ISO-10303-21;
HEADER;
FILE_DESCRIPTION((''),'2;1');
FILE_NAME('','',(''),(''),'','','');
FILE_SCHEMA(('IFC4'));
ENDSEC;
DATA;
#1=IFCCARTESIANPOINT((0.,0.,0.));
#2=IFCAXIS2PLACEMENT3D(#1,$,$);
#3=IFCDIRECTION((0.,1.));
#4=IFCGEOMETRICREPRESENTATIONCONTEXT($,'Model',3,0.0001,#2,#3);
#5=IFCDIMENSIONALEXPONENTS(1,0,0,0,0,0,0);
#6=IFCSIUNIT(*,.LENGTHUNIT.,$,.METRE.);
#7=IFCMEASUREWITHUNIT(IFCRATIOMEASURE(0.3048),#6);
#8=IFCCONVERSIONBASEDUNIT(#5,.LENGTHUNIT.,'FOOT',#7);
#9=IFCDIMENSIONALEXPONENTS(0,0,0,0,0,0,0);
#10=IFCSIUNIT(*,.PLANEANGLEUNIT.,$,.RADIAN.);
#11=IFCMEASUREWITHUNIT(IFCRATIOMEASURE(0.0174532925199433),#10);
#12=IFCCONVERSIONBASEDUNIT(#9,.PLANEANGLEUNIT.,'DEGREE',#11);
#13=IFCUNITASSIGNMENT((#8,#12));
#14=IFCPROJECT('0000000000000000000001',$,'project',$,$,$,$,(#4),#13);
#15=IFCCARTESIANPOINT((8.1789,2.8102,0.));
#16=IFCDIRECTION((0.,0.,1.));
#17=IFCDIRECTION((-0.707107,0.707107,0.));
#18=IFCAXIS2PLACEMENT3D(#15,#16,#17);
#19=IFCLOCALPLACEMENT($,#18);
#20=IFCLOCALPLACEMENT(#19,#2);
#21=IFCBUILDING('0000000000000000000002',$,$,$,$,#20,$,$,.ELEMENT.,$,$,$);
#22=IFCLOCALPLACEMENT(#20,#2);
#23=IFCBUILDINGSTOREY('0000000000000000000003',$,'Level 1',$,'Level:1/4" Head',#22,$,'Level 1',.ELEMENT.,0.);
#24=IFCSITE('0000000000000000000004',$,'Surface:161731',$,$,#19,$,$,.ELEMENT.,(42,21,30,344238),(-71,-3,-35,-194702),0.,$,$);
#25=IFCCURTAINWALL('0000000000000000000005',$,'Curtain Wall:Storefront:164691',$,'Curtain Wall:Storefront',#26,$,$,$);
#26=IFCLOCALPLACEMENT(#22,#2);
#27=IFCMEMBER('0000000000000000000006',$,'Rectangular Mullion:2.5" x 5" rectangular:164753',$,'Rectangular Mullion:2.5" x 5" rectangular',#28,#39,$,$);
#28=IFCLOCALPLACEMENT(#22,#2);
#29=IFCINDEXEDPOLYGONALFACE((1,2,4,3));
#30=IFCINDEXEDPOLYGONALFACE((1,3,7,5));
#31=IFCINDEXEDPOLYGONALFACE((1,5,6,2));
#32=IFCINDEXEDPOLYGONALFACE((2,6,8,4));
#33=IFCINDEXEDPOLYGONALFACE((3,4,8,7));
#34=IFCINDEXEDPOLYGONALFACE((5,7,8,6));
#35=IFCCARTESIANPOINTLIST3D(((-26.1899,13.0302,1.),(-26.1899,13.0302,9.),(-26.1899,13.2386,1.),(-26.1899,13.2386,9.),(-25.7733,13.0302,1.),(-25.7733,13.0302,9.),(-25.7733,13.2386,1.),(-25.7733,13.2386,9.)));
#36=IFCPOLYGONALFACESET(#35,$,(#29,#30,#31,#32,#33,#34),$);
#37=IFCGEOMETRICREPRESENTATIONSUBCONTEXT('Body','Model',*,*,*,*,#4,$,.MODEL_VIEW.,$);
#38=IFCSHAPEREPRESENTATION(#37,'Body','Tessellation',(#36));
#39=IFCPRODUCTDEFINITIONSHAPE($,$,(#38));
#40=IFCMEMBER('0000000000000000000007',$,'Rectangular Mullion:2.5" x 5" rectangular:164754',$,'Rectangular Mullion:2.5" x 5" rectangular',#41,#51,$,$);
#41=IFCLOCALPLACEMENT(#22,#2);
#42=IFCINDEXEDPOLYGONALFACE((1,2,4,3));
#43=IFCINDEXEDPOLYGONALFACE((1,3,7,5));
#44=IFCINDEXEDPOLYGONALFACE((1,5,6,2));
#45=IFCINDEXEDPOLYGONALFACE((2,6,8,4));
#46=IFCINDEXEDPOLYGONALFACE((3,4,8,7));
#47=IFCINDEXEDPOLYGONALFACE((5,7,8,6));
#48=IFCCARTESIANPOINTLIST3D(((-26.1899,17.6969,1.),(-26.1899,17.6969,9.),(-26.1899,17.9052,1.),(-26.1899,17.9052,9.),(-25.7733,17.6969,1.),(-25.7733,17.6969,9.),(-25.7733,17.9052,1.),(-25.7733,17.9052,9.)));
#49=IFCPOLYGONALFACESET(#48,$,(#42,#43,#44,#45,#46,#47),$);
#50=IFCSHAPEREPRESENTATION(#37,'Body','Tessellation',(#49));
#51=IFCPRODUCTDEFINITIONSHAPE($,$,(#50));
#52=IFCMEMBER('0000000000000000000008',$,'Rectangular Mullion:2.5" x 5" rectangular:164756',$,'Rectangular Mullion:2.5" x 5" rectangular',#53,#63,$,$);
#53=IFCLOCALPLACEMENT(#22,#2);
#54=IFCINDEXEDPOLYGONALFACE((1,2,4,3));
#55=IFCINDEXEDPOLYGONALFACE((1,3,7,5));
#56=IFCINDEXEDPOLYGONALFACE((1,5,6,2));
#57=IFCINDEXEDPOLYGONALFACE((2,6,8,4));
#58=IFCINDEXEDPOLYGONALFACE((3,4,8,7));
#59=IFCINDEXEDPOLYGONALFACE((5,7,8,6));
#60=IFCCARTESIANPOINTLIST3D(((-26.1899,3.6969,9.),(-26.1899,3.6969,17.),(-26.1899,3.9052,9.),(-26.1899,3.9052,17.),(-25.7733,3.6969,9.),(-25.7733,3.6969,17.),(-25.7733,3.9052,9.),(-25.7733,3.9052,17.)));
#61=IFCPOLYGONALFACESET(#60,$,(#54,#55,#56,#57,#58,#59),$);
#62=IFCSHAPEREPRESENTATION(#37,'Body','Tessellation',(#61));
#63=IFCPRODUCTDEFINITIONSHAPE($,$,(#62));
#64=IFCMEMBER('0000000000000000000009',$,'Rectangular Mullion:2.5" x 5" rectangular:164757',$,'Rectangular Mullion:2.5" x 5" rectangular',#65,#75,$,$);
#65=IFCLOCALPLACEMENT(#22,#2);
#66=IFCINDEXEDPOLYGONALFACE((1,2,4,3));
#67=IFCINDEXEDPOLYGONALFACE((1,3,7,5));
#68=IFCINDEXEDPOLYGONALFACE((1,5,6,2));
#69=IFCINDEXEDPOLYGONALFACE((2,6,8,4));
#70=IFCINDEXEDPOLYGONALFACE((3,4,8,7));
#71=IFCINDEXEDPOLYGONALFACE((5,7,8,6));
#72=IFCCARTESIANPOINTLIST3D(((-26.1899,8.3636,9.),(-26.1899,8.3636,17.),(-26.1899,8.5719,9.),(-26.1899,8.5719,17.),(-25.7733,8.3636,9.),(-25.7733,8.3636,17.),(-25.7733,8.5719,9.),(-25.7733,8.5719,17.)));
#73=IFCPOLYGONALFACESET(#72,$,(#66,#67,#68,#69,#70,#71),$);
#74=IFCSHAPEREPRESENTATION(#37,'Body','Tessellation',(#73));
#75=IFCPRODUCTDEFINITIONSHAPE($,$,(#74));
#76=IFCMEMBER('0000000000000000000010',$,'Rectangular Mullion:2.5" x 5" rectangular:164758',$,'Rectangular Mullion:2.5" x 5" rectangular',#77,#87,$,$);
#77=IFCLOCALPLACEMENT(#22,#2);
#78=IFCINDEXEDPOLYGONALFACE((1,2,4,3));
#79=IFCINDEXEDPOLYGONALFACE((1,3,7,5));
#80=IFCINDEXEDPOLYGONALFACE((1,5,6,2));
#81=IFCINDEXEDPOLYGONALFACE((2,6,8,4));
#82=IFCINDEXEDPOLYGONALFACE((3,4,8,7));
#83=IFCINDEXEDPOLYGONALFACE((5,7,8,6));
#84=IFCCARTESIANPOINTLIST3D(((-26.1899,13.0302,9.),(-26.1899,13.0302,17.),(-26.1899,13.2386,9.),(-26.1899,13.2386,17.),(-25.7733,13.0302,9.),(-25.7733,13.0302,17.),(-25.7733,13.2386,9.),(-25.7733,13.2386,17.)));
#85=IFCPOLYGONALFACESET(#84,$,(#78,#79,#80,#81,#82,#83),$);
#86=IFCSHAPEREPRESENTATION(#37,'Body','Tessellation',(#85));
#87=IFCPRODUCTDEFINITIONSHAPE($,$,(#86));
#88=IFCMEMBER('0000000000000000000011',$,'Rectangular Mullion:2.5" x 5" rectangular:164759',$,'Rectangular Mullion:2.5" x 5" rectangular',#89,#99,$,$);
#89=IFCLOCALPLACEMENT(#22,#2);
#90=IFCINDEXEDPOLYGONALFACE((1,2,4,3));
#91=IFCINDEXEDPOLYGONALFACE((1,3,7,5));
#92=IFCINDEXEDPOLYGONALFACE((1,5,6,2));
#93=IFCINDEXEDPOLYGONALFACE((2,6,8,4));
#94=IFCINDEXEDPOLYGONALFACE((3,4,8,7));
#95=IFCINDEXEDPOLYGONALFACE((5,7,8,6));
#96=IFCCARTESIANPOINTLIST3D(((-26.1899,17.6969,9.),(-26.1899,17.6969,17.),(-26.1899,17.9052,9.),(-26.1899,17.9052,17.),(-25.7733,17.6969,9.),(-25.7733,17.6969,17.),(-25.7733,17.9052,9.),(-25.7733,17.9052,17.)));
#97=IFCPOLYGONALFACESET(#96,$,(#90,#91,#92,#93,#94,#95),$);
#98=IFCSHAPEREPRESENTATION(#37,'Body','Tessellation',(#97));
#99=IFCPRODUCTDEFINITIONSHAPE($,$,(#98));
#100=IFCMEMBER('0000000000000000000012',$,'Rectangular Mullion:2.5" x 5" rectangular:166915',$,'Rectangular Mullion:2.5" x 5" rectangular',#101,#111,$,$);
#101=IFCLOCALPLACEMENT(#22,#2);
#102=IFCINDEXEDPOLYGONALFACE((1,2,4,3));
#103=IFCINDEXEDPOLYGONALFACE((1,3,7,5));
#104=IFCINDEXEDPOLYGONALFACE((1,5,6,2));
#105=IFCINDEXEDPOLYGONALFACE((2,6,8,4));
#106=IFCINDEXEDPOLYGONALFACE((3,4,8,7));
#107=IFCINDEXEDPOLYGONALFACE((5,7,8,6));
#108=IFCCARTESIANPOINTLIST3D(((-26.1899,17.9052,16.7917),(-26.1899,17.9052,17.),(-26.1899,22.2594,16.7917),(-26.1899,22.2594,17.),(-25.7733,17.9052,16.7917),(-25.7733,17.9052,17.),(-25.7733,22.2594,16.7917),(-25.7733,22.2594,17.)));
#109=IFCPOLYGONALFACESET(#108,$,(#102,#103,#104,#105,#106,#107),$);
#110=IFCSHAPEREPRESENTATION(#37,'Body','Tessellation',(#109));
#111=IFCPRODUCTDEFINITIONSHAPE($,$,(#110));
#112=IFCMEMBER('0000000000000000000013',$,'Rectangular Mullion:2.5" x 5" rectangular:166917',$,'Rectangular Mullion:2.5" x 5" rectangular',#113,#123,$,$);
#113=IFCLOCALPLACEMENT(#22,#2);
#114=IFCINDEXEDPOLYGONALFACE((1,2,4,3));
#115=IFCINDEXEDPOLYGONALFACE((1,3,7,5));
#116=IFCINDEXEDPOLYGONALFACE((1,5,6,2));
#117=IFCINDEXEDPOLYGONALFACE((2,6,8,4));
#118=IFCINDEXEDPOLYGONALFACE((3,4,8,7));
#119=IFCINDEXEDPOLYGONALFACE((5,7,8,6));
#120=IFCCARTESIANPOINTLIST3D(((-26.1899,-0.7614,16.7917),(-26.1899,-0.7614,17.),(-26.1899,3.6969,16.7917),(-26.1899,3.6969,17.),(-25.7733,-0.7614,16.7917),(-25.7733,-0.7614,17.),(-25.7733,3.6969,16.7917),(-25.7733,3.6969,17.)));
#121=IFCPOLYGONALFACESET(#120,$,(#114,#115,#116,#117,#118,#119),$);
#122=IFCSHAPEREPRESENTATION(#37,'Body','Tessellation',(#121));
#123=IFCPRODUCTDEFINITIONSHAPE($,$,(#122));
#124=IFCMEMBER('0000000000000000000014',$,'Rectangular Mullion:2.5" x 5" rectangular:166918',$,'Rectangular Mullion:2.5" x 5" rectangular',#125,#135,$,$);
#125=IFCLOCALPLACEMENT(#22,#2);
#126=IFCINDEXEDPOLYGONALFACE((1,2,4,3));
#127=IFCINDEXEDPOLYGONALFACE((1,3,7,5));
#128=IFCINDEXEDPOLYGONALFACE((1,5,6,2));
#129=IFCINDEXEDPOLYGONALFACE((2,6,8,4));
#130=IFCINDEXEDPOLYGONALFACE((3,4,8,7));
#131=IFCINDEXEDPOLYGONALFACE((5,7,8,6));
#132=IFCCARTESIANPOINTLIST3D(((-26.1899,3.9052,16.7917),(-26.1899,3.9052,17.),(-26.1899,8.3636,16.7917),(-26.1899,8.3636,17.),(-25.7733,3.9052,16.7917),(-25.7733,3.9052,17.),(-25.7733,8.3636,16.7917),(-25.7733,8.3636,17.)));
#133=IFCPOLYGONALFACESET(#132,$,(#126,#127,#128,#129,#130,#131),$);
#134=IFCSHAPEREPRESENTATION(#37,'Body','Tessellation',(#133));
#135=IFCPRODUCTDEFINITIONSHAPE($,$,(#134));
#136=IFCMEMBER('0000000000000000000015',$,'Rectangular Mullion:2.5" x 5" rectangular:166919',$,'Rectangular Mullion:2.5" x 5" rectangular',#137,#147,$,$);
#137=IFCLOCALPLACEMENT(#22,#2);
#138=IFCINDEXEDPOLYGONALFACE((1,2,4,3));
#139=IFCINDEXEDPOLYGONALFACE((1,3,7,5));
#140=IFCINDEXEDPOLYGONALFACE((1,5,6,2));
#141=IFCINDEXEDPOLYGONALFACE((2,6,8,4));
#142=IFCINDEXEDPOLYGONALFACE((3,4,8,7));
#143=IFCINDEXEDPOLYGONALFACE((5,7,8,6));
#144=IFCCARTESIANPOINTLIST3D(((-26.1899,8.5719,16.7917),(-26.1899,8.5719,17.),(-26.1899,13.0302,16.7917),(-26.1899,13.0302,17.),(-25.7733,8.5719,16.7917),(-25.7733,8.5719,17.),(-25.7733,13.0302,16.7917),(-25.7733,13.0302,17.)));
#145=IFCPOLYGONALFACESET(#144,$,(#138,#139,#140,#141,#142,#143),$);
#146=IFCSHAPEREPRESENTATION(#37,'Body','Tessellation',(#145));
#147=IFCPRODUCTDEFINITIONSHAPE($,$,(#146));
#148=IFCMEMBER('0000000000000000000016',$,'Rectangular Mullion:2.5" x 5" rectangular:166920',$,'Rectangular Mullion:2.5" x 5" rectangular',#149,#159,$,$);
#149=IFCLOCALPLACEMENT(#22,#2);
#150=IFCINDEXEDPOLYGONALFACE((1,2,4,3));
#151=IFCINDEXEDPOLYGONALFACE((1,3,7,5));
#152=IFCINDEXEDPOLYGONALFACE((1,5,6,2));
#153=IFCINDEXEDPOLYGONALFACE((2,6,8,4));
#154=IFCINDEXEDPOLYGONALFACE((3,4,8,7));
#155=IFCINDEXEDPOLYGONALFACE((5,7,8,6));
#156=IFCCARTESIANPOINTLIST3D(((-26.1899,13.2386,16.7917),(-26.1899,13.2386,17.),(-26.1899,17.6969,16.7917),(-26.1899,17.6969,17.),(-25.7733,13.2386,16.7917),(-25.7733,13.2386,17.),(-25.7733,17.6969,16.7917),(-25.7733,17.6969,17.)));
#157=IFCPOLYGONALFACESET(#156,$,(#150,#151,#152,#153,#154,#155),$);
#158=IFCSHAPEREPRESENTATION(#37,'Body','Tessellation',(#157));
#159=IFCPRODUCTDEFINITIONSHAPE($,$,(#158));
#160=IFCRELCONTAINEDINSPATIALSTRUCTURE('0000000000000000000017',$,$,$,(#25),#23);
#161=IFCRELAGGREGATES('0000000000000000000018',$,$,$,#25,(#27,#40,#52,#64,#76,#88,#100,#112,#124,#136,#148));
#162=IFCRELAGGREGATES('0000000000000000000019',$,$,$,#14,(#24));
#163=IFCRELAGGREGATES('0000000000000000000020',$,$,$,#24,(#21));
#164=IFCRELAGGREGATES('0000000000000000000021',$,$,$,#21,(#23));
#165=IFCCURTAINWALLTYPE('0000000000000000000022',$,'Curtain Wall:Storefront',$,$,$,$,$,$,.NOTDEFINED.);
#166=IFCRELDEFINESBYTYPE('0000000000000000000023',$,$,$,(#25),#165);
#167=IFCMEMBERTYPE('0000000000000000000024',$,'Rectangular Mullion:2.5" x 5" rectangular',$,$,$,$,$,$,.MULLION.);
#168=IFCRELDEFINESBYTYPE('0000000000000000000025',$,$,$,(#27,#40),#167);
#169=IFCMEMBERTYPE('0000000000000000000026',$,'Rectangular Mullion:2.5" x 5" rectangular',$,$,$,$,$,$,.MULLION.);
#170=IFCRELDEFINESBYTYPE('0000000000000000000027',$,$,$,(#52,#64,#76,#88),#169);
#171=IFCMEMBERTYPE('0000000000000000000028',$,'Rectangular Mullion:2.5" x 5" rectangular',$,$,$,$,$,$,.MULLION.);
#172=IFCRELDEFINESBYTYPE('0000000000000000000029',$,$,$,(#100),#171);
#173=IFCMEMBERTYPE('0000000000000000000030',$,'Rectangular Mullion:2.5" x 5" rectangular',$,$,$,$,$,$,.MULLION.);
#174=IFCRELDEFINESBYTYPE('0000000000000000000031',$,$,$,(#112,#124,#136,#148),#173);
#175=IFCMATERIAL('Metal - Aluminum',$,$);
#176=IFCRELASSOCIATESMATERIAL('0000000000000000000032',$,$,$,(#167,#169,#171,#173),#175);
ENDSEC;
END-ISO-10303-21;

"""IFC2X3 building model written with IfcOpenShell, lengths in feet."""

from ifc_helpers import new_model, entity, si_unit, converted_unit, direction, frame, origin, origin_2d_with_axis, place, context, subcontext, project, spatial, rectangle, extrude, source, transform, mapped, material, type_object, type_shapes, element, aggregate, save


model = new_model("IFC2X3")

# Units and contexts
model_context = context("Model", 3, precision=0.0001, world=origin(), true_north=direction((0.0, 1.0)))
body_context = subcontext(model_context, "Body", "Model", "MODEL_VIEW")
ifc_project = project(units=[converted_unit("LENGTHUNIT", "FOOT", entity("IfcRatioMeasure", 0.3048), si_unit("LENGTHUNIT", "METRE"), dimensions=[1, 0, 0, 0, 0, 0, 0]), converted_unit("PLANEANGLEUNIT", "DEGREE", entity("IfcRatioMeasure", 0.0174532925199433), si_unit("PLANEANGLEUNIT", "RADIAN"), dimensions=[0, 0, 0, 0, 0, 0, 0])], contexts=[model_context])

# Site, building, storey
site_placement = place(None, frame((8.1789, 2.8102, 0.0), z_axis=(0.0, 0.0, 1.0), x_axis=(-0.707107, 0.707107, 0.0)))
site = spatial("IfcSite", under=ifc_project, at=site_placement, Name="Surface:161731", CompositionType="ELEMENT", RefLatitude=(42, 21, 30, 344238), RefLongitude=(-71, -3, -35, -194702), RefElevation=0.0)
building_placement = place(site_placement, origin())
building = spatial("IfcBuilding", under=site, at=building_placement, CompositionType="ELEMENT")
storey_placement = place(building_placement, origin())
storey = spatial("IfcBuildingStorey", under=building, at=storey_placement, Name="Level 1", ObjectType="Level:1/4\" Head", LongName="Level 1", CompositionType="ELEMENT", Elevation=0.0)

# Curtain wall, members
curtain_wall_type = type_object("IfcCurtainWallType", Name="Curtain Wall:Storefront", PredefinedType="NOTDEFINED")
curtain_wall_placement = place(storey_placement, origin())
curtain_wall = element("IfcCurtainWall", 1, at=curtain_wall_placement, inside=storey, type_object=curtain_wall_type, Name="Curtain Wall:Storefront:164691", ObjectType="Curtain Wall:Storefront")
ifc_material_1 = material(Name="Metal - Aluminum")
member_type_1 = type_object("IfcMemberType", Name="Rectangular Mullion:2.5\" x 5\" rectangular", PredefinedType="MULLION", material=ifc_material_1)
shared_shape_1 = source(origin(), body_context, "Body", "SweptSolid", [
    extrude(rectangle(XDim=0.4167, YDim=0.2083, at=origin_2d_with_axis()), frame((0.0, 0.0, -8.0), z_axis=(0.0, 0.0, 1.0), x_axis=(0.0, -1.0, 0.0)), (0.0, 0.0, 1.0), 8.0),
])
type_shapes(member_type_1, [shared_shape_1])
member_1_placement = place(curtain_wall_placement, frame((-25.9816, 13.1344, 1.0), z_axis=(0.0, 0.0, -1.0), x_axis=(0.0, 1.0, 0.0)))
member_1 = element("IfcMember", 2, at=member_1_placement, type_object=member_type_1, Name="Rectangular Mullion:2.5\" x 5\" rectangular:164753", ObjectType="Rectangular Mullion:2.5\" x 5\" rectangular", context=body_context, shape_type="MappedRepresentation", body=[
    mapped(shared_shape_1, transform((0.0, 0.0, 0.0), scale=1.0)),
])
member_2_placement = place(curtain_wall_placement, frame((-25.9816, 17.8011, 1.0), z_axis=(0.0, 0.0, -1.0), x_axis=(0.0, 1.0, 0.0)))
member_2 = element("IfcMember", 3, at=member_2_placement, type_object=member_type_1, Name="Rectangular Mullion:2.5\" x 5\" rectangular:164754", ObjectType="Rectangular Mullion:2.5\" x 5\" rectangular", context=body_context, shape_type="MappedRepresentation", body=[
    mapped(shared_shape_1, transform((0.0, 0.0, 0.0), scale=1.0)),
])
member_type_2 = type_object("IfcMemberType", Name="Rectangular Mullion:2.5\" x 5\" rectangular", PredefinedType="MULLION", material=ifc_material_1)
shared_shape_2 = source(origin(), body_context, "Body", "SweptSolid", [
    extrude(rectangle(XDim=0.4167, YDim=0.2083, at=origin_2d_with_axis()), frame((0.0, 0.0, -8.0), z_axis=(0.0, 0.0, 1.0), x_axis=(0.0, -1.0, 0.0)), (0.0, 0.0, 1.0), 8.0),
])
type_shapes(member_type_2, [shared_shape_2])
member_3_placement = place(curtain_wall_placement, frame((-25.9816, 3.8011, 9.0), z_axis=(0.0, 0.0, -1.0), x_axis=(0.0, 1.0, 0.0)))
member_3 = element("IfcMember", 4, at=member_3_placement, type_object=member_type_2, Name="Rectangular Mullion:2.5\" x 5\" rectangular:164756", ObjectType="Rectangular Mullion:2.5\" x 5\" rectangular", context=body_context, shape_type="MappedRepresentation", body=[
    mapped(shared_shape_2, transform((0.0, 0.0, 0.0), scale=1.0)),
])
member_4_placement = place(curtain_wall_placement, frame((-25.9816, 8.4677, 9.0), z_axis=(0.0, 0.0, -1.0), x_axis=(0.0, 1.0, 0.0)))
member_4 = element("IfcMember", 5, at=member_4_placement, type_object=member_type_2, Name="Rectangular Mullion:2.5\" x 5\" rectangular:164757", ObjectType="Rectangular Mullion:2.5\" x 5\" rectangular", context=body_context, shape_type="MappedRepresentation", body=[
    mapped(shared_shape_2, transform((0.0, 0.0, 0.0), scale=1.0)),
])
member_5_placement = place(curtain_wall_placement, frame((-25.9816, 13.1344, 9.0), z_axis=(0.0, 0.0, -1.0), x_axis=(0.0, 1.0, 0.0)))
member_5 = element("IfcMember", 6, at=member_5_placement, type_object=member_type_2, Name="Rectangular Mullion:2.5\" x 5\" rectangular:164758", ObjectType="Rectangular Mullion:2.5\" x 5\" rectangular", context=body_context, shape_type="MappedRepresentation", body=[
    mapped(shared_shape_2, transform((0.0, 0.0, 0.0), scale=1.0)),
])
member_6_placement = place(curtain_wall_placement, frame((-25.9816, 17.8011, 9.0), z_axis=(0.0, 0.0, -1.0), x_axis=(0.0, 1.0, 0.0)))
member_6 = element("IfcMember", 7, at=member_6_placement, type_object=member_type_2, Name="Rectangular Mullion:2.5\" x 5\" rectangular:164759", ObjectType="Rectangular Mullion:2.5\" x 5\" rectangular", context=body_context, shape_type="MappedRepresentation", body=[
    mapped(shared_shape_2, transform((0.0, 0.0, 0.0), scale=1.0)),
])
member_type_3 = type_object("IfcMemberType", Name="Rectangular Mullion:2.5\" x 5\" rectangular", PredefinedType="MULLION", material=ifc_material_1)
shared_shape_3 = source(origin(), body_context, "Body", "SweptSolid", [
    extrude(rectangle(XDim=0.4167, YDim=0.2083, at=origin_2d_with_axis()), frame((-0.1042, 0.0, -4.3542), z_axis=(0.0, 0.0, 1.0), x_axis=(0.0, -1.0, 0.0)), (0.0, 0.0, 1.0), 4.3542),
])
type_shapes(member_type_3, [shared_shape_3])
member_7_placement = place(curtain_wall_placement, frame((-25.9816, 22.2594, 17.0), z_axis=(0.0, 1.0, 0.0), x_axis=(0.0, 0.0, 1.0)))
member_7 = element("IfcMember", 8, at=member_7_placement, type_object=member_type_3, Name="Rectangular Mullion:2.5\" x 5\" rectangular:166915", ObjectType="Rectangular Mullion:2.5\" x 5\" rectangular", context=body_context, shape_type="MappedRepresentation", body=[
    mapped(shared_shape_3, transform((0.0, 0.0, 0.0), scale=1.0)),
])
member_type_4 = type_object("IfcMemberType", Name="Rectangular Mullion:2.5\" x 5\" rectangular", PredefinedType="MULLION", material=ifc_material_1)
shared_shape_4 = source(origin(), body_context, "Body", "SweptSolid", [
    extrude(rectangle(XDim=0.4167, YDim=0.2083, at=origin_2d_with_axis()), frame((-0.1042, 0.0, -4.4583), z_axis=(0.0, 0.0, 1.0), x_axis=(0.0, -1.0, 0.0)), (0.0, 0.0, 1.0), 4.4583),
])
type_shapes(member_type_4, [shared_shape_4])
member_8_placement = place(curtain_wall_placement, frame((-25.9816, 3.6969, 17.0), z_axis=(0.0, 1.0, 0.0), x_axis=(0.0, 0.0, 1.0)))
member_8 = element("IfcMember", 9, at=member_8_placement, type_object=member_type_4, Name="Rectangular Mullion:2.5\" x 5\" rectangular:166917", ObjectType="Rectangular Mullion:2.5\" x 5\" rectangular", context=body_context, shape_type="MappedRepresentation", body=[
    mapped(shared_shape_4, transform((0.0, 0.0, 0.0), scale=1.0)),
])
member_9_placement = place(curtain_wall_placement, frame((-25.9816, 8.3636, 17.0), z_axis=(0.0, 1.0, 0.0), x_axis=(0.0, 0.0, 1.0)))
member_9 = element("IfcMember", 10, at=member_9_placement, type_object=member_type_4, Name="Rectangular Mullion:2.5\" x 5\" rectangular:166918", ObjectType="Rectangular Mullion:2.5\" x 5\" rectangular", context=body_context, shape_type="MappedRepresentation", body=[
    mapped(shared_shape_4, transform((0.0, 0.0, 0.0), scale=1.0)),
])
member_10_placement = place(curtain_wall_placement, frame((-25.9816, 13.0302, 17.0), z_axis=(0.0, 1.0, 0.0), x_axis=(0.0, 0.0, 1.0)))
member_10 = element("IfcMember", 11, at=member_10_placement, type_object=member_type_4, Name="Rectangular Mullion:2.5\" x 5\" rectangular:166919", ObjectType="Rectangular Mullion:2.5\" x 5\" rectangular", context=body_context, shape_type="MappedRepresentation", body=[
    mapped(shared_shape_4, transform((0.0, 0.0, 0.0), scale=1.0)),
])
member_11_placement = place(curtain_wall_placement, frame((-25.9816, 17.6969, 17.0), z_axis=(0.0, 1.0, 0.0), x_axis=(0.0, 0.0, 1.0)))
member_11 = element("IfcMember", 12, at=member_11_placement, type_object=member_type_4, Name="Rectangular Mullion:2.5\" x 5\" rectangular:166920", ObjectType="Rectangular Mullion:2.5\" x 5\" rectangular", context=body_context, shape_type="MappedRepresentation", body=[
    mapped(shared_shape_4, transform((0.0, 0.0, 0.0), scale=1.0)),
])
aggregate(curtain_wall, [member_1, member_2, member_3, member_4, member_5, member_6, member_7, member_8, member_9, member_10, member_11])

save(model, "model.ifc")
